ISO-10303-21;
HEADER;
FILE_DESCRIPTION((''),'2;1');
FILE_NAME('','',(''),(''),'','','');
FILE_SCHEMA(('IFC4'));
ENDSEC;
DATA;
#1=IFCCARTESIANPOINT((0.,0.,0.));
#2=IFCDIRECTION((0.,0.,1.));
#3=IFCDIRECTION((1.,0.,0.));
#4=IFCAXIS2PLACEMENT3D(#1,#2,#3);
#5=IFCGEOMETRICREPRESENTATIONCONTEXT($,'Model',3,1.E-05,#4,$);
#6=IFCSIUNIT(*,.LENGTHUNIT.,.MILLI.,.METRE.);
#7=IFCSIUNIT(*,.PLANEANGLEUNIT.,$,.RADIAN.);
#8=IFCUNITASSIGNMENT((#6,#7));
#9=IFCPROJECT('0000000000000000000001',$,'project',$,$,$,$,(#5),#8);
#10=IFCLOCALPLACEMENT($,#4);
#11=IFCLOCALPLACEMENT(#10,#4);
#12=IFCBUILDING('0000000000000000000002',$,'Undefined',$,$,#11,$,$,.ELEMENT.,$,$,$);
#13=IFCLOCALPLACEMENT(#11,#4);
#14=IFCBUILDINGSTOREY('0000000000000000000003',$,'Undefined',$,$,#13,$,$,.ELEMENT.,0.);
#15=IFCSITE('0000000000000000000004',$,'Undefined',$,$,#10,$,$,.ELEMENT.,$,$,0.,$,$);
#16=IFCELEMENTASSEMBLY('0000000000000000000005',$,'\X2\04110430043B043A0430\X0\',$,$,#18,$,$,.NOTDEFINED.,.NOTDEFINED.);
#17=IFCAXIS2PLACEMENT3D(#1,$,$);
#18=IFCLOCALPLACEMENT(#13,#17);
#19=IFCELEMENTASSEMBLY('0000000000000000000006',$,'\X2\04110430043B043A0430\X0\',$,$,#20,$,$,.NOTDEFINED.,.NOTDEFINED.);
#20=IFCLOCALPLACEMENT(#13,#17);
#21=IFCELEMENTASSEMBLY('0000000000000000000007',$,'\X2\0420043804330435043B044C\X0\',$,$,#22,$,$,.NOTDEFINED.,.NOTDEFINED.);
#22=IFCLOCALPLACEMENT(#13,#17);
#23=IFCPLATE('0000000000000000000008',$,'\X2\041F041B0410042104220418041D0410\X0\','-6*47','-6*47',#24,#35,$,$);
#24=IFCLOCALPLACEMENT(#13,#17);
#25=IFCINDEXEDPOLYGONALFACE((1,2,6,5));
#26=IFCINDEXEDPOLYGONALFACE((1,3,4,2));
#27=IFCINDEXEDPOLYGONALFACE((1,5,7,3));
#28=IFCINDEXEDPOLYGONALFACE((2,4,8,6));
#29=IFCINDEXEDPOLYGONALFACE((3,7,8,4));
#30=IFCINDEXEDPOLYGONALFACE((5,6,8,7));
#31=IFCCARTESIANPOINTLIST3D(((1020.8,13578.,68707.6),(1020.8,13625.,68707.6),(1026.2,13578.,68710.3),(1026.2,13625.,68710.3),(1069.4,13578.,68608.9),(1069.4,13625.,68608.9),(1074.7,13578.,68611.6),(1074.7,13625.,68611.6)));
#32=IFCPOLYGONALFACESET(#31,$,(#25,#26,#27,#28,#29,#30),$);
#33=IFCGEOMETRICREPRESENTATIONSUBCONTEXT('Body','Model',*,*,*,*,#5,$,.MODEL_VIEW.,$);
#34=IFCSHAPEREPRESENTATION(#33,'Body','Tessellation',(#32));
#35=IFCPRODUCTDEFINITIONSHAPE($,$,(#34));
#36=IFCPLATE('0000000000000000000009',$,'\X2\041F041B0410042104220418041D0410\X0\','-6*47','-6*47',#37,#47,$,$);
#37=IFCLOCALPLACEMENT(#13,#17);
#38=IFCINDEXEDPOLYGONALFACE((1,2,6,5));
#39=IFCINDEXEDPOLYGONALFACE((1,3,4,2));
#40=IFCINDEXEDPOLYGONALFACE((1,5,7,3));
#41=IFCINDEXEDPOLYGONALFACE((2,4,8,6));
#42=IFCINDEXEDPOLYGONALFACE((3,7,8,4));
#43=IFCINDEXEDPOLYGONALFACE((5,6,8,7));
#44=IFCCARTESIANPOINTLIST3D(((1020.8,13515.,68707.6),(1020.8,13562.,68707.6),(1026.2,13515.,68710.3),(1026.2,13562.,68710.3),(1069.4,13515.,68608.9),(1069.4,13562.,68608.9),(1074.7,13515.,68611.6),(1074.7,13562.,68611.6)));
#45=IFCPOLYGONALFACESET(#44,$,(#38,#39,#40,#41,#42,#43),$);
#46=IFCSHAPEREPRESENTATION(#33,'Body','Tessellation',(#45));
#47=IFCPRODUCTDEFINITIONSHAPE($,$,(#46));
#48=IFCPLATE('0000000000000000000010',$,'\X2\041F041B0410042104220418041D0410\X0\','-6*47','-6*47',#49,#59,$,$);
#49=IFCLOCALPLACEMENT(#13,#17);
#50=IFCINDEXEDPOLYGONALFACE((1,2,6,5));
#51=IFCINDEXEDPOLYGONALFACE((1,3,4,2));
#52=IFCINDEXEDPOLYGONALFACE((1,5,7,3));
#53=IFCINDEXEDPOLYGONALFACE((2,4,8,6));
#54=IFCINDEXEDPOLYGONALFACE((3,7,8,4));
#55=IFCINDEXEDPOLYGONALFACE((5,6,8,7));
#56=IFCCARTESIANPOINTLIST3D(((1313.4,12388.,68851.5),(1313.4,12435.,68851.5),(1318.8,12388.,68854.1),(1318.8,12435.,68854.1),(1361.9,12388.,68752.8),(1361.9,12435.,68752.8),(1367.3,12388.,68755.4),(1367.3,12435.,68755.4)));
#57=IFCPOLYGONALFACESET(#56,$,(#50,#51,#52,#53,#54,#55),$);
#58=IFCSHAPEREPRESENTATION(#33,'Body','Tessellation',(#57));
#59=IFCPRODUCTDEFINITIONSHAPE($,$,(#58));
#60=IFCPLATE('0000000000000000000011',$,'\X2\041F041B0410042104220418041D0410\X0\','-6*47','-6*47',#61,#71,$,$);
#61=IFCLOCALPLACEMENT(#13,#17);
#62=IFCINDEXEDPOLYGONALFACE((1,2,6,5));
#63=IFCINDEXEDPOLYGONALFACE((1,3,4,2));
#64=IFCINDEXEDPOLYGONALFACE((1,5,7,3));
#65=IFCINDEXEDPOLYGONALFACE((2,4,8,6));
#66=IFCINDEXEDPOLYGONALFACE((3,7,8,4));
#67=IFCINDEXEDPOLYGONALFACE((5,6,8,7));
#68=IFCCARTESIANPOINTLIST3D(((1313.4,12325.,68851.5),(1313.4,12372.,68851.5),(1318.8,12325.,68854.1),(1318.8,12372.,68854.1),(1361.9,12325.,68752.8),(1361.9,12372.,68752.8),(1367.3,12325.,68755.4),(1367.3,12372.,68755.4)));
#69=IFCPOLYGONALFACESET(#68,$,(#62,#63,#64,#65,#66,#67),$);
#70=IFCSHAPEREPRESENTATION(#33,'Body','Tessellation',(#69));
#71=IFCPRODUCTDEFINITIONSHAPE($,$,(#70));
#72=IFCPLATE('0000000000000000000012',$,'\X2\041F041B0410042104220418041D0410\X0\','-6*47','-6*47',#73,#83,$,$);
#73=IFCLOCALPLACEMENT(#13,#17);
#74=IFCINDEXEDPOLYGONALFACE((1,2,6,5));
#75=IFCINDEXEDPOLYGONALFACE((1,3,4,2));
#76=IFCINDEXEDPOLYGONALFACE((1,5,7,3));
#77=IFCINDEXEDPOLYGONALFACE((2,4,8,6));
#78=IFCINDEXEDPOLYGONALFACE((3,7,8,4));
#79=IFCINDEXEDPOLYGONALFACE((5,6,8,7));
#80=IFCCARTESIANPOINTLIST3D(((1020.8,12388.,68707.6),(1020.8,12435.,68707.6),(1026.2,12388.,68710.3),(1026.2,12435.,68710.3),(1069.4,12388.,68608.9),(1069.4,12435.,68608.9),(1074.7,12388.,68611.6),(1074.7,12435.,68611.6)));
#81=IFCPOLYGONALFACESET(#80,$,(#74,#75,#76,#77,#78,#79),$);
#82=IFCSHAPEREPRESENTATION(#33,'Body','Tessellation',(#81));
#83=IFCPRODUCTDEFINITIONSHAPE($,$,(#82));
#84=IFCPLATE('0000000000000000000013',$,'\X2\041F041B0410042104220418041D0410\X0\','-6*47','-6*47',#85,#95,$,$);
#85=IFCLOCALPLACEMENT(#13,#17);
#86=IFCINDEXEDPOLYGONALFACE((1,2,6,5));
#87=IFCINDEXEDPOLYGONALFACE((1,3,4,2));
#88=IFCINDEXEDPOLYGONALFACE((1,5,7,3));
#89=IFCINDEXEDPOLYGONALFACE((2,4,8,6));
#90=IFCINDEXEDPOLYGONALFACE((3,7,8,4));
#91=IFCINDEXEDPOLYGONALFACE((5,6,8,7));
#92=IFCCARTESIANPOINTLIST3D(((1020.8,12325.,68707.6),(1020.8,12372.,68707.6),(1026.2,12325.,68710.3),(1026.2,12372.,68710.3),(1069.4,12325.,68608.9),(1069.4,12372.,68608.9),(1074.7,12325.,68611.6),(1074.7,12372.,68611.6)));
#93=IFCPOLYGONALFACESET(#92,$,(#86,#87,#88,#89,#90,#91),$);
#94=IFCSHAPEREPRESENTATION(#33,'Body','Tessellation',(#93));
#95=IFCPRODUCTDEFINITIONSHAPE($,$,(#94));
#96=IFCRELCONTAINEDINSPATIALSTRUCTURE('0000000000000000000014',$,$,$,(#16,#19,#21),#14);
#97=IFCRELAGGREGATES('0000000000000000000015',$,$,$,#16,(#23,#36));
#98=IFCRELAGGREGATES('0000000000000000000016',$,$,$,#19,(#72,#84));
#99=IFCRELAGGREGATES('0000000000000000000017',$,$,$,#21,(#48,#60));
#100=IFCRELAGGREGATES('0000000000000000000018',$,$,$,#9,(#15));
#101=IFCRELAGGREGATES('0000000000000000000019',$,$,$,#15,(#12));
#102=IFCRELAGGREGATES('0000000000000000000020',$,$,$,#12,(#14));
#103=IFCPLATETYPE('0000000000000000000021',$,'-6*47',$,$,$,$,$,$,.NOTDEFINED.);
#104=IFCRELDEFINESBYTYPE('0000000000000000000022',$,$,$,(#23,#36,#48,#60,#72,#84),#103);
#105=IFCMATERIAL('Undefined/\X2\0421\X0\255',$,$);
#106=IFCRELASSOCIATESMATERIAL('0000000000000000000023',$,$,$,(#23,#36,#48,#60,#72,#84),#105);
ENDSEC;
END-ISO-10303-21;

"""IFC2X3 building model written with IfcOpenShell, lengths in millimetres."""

from ifc_helpers import new_model, si_unit, frame, origin_with_axes, origin_2d_with_axis, place, context, subcontext, project, spatial, polyline, rectangle, outline, extrude, boolean, material, type_object, element, aggregate, save


model = new_model("IFC2X3")

# Units and contexts
model_context = context("Model", 3, precision=1e-05, world=origin_with_axes())
body_context = subcontext(model_context, "Body", "Model", "MODEL_VIEW")
ifc_project = project(units=[si_unit("LENGTHUNIT", "METRE", prefix="MILLI"), si_unit("PLANEANGLEUNIT", "RADIAN")], contexts=[model_context])

# Site, building, storey
site_placement = place(None, origin_with_axes())
site = spatial("IfcSite", under=ifc_project, at=site_placement, Name="Undefined", CompositionType="ELEMENT", RefElevation=0.0)
building_placement = place(site_placement, origin_with_axes())
building = spatial("IfcBuilding", under=site, at=building_placement, Name="Undefined", CompositionType="ELEMENT")
storey_placement = place(building_placement, origin_with_axes())
storey = spatial("IfcBuildingStorey", under=building, at=storey_placement, Name="Undefined", CompositionType="ELEMENT", Elevation=0.0)

# Element assembly
assembly_1_placement = place(storey_placement, origin_with_axes())
assembly_1 = element("IfcElementAssembly", 1, at=assembly_1_placement, inside=storey, Name="Балка", AssemblyPlace="NOTDEFINED", PredefinedType="NOTDEFINED")
ifc_material_1 = material(Name="Undefined/С255")

# Element assembly
assembly_2_placement = place(storey_placement, origin_with_axes())
assembly_2 = element("IfcElementAssembly", 2, at=assembly_2_placement, inside=storey, Name="Балка", AssemblyPlace="NOTDEFINED", PredefinedType="NOTDEFINED")

# Element assembly
assembly_3_placement = place(storey_placement, origin_with_axes())
assembly_3 = element("IfcElementAssembly", 3, at=assembly_3_placement, inside=storey, Name="Ригель", AssemblyPlace="NOTDEFINED", PredefinedType="NOTDEFINED")

# Shared definitions
plate_type = type_object("IfcPlateType", Name="-6*47", PredefinedType="NOTDEFINED")

# Plates
plate_1_placement = place(assembly_1_placement, frame((1023.5, 13515.0, 68709.0), z_axis=(0.897399, 0.0, 0.441221), x_axis=(0.441221, 0.0, -0.897399)))
plate_1 = element("IfcPlate", 4, at=plate_1_placement, type_object=plate_type, material=ifc_material_1, Name="ПЛАСТИНА", Description="-6*47", ObjectType="-6*47", context=body_context, shape_type="CSG", body=[
    boolean("DIFFERENCE", extrude(outline(polyline([(0.0, 0.0), (110.0, 0.0), (110.0, 110.0), (0.0, 110.0), (0.0, 0.0)])), frame((0.0, 0.0, -3.0), z_axis=(0.0, 0.0, 1.0), x_axis=(1.0, 0.0, 0.0)), (0.0, 0.0, 1.0), 6.0), extrude(rectangle(XDim=26.0, YDim=130.0, at=origin_2d_with_axis()), frame((55.0, -3.0, 0.0), z_axis=(0.0, 1.0, 0.0), x_axis=(0.0, 0.0, -1.0)), (0.0, 0.0, 1.0), 66.0)),
])
plate_2_placement = place(assembly_1_placement, frame((1023.5, 13515.0, 68709.0), z_axis=(0.897399, 0.0, 0.441221), x_axis=(0.441221, 0.0, -0.897399)))
plate_2 = element("IfcPlate", 5, at=plate_2_placement, type_object=plate_type, material=ifc_material_1, Name="ПЛАСТИНА", Description="-6*47", ObjectType="-6*47", context=body_context, shape_type="CSG", body=[
    boolean("DIFFERENCE", extrude(outline(polyline([(0.0, 0.0), (110.0, 0.0), (110.0, 110.0), (0.0, 110.0), (0.0, 0.0)])), frame((0.0, 0.0, -3.0), z_axis=(0.0, 0.0, 1.0), x_axis=(1.0, 0.0, 0.0)), (0.0, 0.0, 1.0), 6.0), extrude(rectangle(XDim=26.0, YDim=130.0, at=origin_2d_with_axis()), frame((55.0, 47.0, 0.0), z_axis=(0.0, 1.0, 0.0), x_axis=(0.0, 0.0, -1.0)), (0.0, 0.0, 1.0), 66.0)),
])
aggregate(assembly_1, [plate_1, plate_2])
plate_3_placement = place(assembly_3_placement, frame((1364.6, 12325.0, 68754.1), z_axis=(-0.897399, 0.0, -0.441221), x_axis=(-0.441221, 0.0, 0.897399)))
plate_3 = element("IfcPlate", 6, at=plate_3_placement, type_object=plate_type, material=ifc_material_1, Name="ПЛАСТИНА", Description="-6*47", ObjectType="-6*47", context=body_context, shape_type="CSG", body=[
    boolean("DIFFERENCE", extrude(outline(polyline([(0.0, 0.0), (110.0, 0.0), (110.0, 110.0), (0.0, 110.0), (0.0, 0.0)])), frame((0.0, 0.0, -3.0), z_axis=(0.0, 0.0, 1.0), x_axis=(1.0, 0.0, 0.0)), (0.0, 0.0, 1.0), 6.0), extrude(rectangle(XDim=26.0, YDim=130.0, at=origin_2d_with_axis()), frame((55.0, -3.0, 0.0), z_axis=(0.0, 1.0, 0.0), x_axis=(0.0, 0.0, -1.0)), (0.0, 0.0, 1.0), 66.0)),
])
plate_4_placement = place(assembly_3_placement, frame((1364.6, 12325.0, 68754.1), z_axis=(-0.897399, 0.0, -0.441221), x_axis=(-0.441221, 0.0, 0.897399)))
plate_4 = element("IfcPlate", 7, at=plate_4_placement, type_object=plate_type, material=ifc_material_1, Name="ПЛАСТИНА", Description="-6*47", ObjectType="-6*47", context=body_context, shape_type="CSG", body=[
    boolean("DIFFERENCE", extrude(outline(polyline([(0.0, 0.0), (110.0, 0.0), (110.0, 110.0), (0.0, 110.0), (0.0, 0.0)])), frame((0.0, 0.0, -3.0), z_axis=(0.0, 0.0, 1.0), x_axis=(1.0, 0.0, 0.0)), (0.0, 0.0, 1.0), 6.0), extrude(rectangle(XDim=26.0, YDim=130.0, at=origin_2d_with_axis()), frame((55.0, 47.0, 0.0), z_axis=(0.0, 1.0, 0.0), x_axis=(0.0, 0.0, -1.0)), (0.0, 0.0, 1.0), 66.0)),
])
plate_5_placement = place(assembly_2_placement, frame((1023.5, 12325.0, 68709.0), z_axis=(0.897399, 0.0, 0.441221), x_axis=(0.441221, 0.0, -0.897399)))
plate_5 = element("IfcPlate", 8, at=plate_5_placement, type_object=plate_type, material=ifc_material_1, Name="ПЛАСТИНА", Description="-6*47", ObjectType="-6*47", context=body_context, shape_type="CSG", body=[
    boolean("DIFFERENCE", extrude(outline(polyline([(0.0, 0.0), (110.0, 0.0), (110.0, 110.0), (0.0, 110.0), (0.0, 0.0)])), frame((0.0, 0.0, -3.0), z_axis=(0.0, 0.0, 1.0), x_axis=(1.0, 0.0, 0.0)), (0.0, 0.0, 1.0), 6.0), extrude(rectangle(XDim=26.0, YDim=130.0, at=origin_2d_with_axis()), frame((55.0, -3.0, 0.0), z_axis=(0.0, 1.0, 0.0), x_axis=(0.0, 0.0, -1.0)), (0.0, 0.0, 1.0), 66.0)),
])
plate_6_placement = place(assembly_2_placement, frame((1023.5, 12325.0, 68709.0), z_axis=(0.897399, 0.0, 0.441221), x_axis=(0.441221, 0.0, -0.897399)))
plate_6 = element("IfcPlate", 9, at=plate_6_placement, type_object=plate_type, material=ifc_material_1, Name="ПЛАСТИНА", Description="-6*47", ObjectType="-6*47", context=body_context, shape_type="CSG", body=[
    boolean("DIFFERENCE", extrude(outline(polyline([(0.0, 0.0), (110.0, 0.0), (110.0, 110.0), (0.0, 110.0), (0.0, 0.0)])), frame((0.0, 0.0, -3.0), z_axis=(0.0, 0.0, 1.0), x_axis=(1.0, 0.0, 0.0)), (0.0, 0.0, 1.0), 6.0), extrude(rectangle(XDim=26.0, YDim=130.0, at=origin_2d_with_axis()), frame((55.0, 47.0, 0.0), z_axis=(0.0, 1.0, 0.0), x_axis=(0.0, 0.0, -1.0)), (0.0, 0.0, 1.0), 66.0)),
])
aggregate(assembly_2, [plate_5, plate_6])

aggregate(assembly_3, [plate_3, plate_4])

save(model, "model.ifc")
